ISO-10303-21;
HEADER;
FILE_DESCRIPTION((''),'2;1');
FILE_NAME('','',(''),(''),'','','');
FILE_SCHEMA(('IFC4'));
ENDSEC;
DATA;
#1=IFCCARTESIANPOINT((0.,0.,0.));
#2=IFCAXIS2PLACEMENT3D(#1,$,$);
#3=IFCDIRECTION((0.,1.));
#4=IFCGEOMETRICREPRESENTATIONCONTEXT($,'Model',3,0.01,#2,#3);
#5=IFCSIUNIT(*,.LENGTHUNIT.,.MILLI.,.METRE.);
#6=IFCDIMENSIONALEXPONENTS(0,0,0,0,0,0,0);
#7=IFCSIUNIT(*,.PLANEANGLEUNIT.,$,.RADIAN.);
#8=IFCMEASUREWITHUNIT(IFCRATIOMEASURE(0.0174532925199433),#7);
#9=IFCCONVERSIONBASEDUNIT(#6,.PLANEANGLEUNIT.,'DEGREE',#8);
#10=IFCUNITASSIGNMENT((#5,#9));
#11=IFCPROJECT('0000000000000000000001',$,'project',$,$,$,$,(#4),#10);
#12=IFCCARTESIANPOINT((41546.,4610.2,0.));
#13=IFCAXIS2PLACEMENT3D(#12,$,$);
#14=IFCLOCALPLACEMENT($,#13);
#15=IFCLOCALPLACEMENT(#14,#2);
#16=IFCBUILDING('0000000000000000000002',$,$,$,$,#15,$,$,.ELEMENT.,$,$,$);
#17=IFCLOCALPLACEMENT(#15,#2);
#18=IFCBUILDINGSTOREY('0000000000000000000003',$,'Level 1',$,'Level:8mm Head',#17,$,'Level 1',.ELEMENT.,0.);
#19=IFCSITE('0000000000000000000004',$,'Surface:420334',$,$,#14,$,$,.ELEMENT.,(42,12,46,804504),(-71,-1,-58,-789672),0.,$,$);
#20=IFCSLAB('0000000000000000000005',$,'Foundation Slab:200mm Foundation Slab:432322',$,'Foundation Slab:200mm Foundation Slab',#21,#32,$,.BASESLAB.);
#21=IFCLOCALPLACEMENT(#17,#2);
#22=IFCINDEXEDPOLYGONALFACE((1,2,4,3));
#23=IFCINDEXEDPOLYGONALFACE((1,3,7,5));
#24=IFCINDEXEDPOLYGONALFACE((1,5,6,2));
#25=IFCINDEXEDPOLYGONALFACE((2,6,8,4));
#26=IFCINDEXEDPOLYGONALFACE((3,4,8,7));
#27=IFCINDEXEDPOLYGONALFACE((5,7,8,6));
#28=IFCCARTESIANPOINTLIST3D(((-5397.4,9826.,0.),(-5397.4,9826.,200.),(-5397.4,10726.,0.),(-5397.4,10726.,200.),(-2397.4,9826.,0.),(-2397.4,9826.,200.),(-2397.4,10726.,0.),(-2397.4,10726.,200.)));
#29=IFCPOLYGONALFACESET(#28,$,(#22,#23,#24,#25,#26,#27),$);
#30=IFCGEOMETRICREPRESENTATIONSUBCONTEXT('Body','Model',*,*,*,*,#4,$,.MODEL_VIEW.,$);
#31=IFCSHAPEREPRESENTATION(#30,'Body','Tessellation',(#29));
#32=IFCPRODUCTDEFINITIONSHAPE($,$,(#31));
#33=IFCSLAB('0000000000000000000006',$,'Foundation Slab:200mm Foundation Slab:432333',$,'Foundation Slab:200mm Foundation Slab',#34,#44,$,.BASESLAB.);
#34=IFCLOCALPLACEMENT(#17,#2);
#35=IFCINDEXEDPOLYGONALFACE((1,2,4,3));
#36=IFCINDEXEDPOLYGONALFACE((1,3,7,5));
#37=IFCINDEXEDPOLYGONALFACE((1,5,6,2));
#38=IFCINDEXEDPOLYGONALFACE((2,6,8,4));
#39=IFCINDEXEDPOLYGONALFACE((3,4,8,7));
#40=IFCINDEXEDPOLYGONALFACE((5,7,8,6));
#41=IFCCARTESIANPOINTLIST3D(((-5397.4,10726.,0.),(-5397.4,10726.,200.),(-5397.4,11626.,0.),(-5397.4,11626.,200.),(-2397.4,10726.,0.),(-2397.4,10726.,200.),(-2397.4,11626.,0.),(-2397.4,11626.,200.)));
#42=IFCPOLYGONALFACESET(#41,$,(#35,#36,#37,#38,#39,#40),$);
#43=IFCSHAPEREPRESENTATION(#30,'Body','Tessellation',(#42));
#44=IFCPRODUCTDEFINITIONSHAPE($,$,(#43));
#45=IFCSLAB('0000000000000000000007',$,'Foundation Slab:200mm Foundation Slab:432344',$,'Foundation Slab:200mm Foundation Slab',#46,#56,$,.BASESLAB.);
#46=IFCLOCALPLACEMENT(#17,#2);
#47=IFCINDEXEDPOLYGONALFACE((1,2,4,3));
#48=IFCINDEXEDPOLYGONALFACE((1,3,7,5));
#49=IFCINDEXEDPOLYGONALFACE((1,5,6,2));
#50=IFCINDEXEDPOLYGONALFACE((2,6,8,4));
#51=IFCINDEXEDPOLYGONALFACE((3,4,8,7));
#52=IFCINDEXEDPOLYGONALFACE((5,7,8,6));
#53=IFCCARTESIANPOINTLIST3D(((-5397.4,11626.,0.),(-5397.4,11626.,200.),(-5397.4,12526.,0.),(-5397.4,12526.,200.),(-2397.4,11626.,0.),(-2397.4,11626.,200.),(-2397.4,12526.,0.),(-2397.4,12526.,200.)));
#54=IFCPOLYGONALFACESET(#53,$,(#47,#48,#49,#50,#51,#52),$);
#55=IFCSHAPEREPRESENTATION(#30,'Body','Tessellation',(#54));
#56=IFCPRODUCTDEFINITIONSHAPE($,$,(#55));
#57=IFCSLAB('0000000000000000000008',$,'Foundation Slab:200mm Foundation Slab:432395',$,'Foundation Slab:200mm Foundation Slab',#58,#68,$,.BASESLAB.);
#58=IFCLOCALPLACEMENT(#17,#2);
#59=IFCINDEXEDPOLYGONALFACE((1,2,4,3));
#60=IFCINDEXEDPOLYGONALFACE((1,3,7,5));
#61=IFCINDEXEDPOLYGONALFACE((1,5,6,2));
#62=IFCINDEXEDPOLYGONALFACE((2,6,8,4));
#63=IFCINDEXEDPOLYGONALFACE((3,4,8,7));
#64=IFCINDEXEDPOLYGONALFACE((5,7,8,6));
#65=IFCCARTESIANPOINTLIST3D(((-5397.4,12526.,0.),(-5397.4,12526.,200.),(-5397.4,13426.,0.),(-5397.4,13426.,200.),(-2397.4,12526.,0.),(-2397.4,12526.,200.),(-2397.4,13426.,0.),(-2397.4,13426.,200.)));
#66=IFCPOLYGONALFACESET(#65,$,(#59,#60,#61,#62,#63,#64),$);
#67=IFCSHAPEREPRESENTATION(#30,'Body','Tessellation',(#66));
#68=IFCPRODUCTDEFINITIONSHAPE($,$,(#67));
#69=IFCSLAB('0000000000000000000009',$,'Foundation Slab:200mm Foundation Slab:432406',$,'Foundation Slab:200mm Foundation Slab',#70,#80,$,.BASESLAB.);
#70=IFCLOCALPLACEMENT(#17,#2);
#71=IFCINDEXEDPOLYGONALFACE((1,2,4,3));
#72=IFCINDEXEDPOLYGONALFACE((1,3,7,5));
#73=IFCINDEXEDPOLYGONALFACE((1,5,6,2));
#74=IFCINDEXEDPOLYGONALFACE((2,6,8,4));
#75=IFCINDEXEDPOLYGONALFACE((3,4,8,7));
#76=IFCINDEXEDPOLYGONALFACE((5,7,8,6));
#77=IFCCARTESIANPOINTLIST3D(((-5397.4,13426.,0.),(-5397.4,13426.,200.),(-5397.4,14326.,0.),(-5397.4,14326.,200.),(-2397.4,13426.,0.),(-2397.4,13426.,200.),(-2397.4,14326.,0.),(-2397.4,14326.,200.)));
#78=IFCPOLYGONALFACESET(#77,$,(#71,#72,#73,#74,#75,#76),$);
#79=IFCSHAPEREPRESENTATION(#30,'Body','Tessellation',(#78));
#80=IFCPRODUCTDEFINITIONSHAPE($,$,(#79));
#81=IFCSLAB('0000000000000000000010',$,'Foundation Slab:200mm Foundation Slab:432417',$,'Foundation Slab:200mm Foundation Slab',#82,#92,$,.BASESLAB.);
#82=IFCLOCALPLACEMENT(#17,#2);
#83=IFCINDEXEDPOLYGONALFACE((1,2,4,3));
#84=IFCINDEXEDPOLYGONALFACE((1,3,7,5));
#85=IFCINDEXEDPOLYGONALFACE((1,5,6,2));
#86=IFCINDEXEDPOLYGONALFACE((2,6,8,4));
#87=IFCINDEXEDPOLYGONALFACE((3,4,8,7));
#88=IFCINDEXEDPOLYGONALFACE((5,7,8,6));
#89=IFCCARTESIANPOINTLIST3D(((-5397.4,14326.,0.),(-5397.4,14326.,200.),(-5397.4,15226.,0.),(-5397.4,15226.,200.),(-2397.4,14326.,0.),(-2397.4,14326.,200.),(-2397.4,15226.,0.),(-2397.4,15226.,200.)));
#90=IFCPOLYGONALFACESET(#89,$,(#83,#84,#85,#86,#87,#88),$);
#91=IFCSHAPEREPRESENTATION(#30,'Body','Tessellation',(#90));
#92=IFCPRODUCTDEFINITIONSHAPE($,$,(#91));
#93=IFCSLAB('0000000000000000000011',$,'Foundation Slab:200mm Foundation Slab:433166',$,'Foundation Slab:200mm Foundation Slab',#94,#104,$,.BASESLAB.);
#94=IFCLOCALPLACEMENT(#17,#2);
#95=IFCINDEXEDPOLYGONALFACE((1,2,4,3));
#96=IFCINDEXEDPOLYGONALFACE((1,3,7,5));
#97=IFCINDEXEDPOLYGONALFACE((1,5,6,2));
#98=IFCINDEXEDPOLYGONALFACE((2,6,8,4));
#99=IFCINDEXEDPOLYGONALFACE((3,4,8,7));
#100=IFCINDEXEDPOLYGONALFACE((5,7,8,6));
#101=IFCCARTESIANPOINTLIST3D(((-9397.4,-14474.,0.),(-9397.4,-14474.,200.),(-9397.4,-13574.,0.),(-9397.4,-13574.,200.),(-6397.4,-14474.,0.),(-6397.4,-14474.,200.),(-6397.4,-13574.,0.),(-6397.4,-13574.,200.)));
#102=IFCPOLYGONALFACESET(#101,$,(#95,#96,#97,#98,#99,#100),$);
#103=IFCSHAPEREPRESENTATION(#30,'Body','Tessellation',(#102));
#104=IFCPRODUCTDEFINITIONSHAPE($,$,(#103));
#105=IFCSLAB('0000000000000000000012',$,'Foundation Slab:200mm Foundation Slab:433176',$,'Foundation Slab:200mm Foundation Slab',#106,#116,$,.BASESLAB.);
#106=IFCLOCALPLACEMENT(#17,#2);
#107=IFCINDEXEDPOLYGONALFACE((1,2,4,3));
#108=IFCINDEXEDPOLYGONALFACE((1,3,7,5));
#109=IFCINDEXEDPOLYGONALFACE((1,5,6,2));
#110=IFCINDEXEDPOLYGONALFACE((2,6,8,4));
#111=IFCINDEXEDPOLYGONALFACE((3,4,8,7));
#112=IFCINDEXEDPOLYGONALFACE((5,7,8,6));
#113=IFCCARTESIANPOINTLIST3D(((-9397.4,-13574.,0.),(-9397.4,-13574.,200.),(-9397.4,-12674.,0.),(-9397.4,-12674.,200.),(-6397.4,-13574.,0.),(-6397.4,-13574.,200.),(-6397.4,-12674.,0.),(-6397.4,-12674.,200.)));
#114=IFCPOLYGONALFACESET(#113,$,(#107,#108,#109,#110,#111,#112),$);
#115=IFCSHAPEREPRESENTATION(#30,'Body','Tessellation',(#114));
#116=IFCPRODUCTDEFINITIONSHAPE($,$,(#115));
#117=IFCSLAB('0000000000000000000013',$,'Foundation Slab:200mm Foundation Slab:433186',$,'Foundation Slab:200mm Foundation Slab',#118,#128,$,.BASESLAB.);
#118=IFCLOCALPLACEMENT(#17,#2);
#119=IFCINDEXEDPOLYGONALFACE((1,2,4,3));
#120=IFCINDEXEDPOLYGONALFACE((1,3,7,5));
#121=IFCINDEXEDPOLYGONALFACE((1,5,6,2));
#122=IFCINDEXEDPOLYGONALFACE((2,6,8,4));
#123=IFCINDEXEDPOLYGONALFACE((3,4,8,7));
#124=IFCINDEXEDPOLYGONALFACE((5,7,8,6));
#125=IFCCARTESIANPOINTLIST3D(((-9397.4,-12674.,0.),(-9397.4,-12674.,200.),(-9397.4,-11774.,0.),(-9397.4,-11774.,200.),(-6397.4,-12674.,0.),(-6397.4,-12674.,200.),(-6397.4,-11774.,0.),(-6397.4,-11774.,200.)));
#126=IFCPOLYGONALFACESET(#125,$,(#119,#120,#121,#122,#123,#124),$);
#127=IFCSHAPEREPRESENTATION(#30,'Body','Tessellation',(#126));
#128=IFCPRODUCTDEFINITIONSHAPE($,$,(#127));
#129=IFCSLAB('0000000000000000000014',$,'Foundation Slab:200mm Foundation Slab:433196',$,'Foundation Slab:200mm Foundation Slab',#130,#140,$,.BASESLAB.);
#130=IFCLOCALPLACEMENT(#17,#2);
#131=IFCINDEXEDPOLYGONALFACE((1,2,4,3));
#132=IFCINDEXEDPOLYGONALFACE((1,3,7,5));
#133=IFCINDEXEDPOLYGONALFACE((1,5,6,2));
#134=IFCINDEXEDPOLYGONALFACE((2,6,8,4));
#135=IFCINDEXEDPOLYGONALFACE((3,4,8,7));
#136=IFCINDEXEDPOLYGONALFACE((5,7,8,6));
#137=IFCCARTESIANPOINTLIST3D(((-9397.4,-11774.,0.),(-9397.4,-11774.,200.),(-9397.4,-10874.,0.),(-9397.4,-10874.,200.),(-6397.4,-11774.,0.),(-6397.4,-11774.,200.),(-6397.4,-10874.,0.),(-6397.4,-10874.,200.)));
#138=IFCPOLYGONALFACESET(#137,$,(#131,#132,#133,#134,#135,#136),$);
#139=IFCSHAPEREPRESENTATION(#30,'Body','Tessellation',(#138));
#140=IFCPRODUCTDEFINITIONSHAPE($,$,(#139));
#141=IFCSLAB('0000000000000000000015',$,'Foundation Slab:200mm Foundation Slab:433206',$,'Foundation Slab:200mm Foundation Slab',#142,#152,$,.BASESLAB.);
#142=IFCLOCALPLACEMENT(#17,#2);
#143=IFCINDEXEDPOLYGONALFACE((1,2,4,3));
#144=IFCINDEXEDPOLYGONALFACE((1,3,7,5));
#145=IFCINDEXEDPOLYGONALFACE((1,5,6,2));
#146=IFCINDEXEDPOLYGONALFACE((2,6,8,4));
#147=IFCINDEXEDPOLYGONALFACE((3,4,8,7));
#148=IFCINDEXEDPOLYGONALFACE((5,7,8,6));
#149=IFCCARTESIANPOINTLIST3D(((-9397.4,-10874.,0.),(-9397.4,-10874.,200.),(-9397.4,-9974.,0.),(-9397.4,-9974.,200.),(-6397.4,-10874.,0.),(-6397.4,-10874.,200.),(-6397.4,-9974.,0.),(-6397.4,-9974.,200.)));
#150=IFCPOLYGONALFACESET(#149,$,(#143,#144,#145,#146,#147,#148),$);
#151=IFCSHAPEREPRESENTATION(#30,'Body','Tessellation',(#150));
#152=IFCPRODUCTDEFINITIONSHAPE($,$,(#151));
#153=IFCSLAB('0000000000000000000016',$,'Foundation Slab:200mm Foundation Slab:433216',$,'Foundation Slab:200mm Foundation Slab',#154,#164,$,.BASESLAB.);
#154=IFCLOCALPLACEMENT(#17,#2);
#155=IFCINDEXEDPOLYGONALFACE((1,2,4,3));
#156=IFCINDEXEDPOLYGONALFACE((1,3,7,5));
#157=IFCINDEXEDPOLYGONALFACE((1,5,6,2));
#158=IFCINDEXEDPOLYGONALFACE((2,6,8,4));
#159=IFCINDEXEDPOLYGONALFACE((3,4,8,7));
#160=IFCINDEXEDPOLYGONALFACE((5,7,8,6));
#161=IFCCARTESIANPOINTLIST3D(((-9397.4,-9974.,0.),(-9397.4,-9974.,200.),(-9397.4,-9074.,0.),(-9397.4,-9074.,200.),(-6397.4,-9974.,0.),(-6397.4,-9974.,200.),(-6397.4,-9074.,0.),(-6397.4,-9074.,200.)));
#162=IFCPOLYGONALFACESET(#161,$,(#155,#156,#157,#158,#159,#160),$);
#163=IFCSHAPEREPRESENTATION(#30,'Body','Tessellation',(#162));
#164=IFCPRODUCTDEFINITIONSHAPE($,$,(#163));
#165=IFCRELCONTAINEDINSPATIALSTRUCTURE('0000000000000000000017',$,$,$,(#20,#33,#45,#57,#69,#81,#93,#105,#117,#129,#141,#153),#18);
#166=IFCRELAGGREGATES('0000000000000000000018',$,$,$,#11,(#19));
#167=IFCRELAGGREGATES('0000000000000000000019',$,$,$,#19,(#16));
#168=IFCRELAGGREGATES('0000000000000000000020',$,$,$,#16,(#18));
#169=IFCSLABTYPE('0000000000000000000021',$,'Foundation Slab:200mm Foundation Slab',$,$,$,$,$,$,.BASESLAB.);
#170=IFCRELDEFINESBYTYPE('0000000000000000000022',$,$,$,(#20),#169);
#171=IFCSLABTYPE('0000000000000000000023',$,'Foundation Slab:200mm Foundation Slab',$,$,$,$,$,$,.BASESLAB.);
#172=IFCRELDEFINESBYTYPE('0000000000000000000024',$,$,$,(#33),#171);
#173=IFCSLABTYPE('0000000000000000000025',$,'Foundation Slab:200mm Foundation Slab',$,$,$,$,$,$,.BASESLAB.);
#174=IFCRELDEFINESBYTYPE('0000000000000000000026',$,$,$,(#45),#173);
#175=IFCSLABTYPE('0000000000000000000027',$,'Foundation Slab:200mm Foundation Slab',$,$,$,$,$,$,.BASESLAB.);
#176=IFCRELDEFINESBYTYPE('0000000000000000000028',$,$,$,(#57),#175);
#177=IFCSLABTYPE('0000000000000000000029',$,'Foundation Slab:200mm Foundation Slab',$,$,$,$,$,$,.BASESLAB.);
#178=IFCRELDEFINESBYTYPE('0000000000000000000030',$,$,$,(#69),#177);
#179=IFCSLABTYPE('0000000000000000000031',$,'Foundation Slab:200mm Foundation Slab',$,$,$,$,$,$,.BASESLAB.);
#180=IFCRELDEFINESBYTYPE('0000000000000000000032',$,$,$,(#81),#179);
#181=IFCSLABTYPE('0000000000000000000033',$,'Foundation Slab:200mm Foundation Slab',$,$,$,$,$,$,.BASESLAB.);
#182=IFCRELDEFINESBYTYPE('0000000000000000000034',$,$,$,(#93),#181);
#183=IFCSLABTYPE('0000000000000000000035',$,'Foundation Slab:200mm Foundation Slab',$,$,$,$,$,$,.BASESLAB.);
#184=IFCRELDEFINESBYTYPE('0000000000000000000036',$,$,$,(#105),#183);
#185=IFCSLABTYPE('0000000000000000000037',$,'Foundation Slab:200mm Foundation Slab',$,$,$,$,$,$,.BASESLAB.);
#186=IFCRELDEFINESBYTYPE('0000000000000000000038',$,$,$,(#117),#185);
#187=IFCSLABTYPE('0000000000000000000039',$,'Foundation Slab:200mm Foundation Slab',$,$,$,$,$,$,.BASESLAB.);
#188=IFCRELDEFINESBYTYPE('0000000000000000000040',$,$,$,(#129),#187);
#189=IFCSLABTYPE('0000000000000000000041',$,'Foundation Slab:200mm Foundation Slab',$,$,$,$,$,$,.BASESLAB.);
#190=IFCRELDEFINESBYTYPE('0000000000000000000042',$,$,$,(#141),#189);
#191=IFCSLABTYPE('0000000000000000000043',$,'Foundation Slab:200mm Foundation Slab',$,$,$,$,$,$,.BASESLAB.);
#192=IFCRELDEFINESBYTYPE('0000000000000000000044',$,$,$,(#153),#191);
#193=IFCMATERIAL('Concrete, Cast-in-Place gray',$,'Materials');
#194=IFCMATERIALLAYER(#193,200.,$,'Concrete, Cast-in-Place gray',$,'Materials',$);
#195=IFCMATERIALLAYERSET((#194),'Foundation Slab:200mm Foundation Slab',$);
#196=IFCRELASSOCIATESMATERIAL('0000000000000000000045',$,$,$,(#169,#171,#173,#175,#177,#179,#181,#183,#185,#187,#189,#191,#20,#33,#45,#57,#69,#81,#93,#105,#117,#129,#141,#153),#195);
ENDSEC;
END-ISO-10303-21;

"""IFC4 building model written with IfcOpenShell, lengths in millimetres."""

from ifc_helpers import new_model, entity, si_unit, converted_unit, direction, frame, frame_2d, origin, origin_2d_with_axis, place, context, subcontext, project, spatial, rectangle, extrude, material, layer, layer_set, layer_usage, type_object, element, save


model = new_model("IFC4")

# Units and contexts
model_context = context("Model", 3, precision=0.01, world=origin(), true_north=direction((0.0, 1.0)))
body_context = subcontext(model_context, "Body", "Model", "MODEL_VIEW")
ifc_project = project(units=[si_unit("LENGTHUNIT", "METRE", prefix="MILLI"), converted_unit("PLANEANGLEUNIT", "DEGREE", entity("IfcRatioMeasure", 0.0174532925199433), si_unit("PLANEANGLEUNIT", "RADIAN"), dimensions=[0, 0, 0, 0, 0, 0, 0])], contexts=[model_context])

# Site, building, storey
site_placement = place(None, frame((41546.0, 4610.2, 0.0)))
site = spatial("IfcSite", under=ifc_project, at=site_placement, Name="Surface:420334", CompositionType="ELEMENT", RefLatitude=(42, 12, 46, 804504), RefLongitude=(-71, -1, -58, -789672), RefElevation=0.0)
building_placement = place(site_placement, origin())
building = spatial("IfcBuilding", under=site, at=building_placement, CompositionType="ELEMENT")
storey_placement = place(building_placement, origin())
storey = spatial("IfcBuildingStorey", under=building, at=storey_placement, Name="Level 1", ObjectType="Level:8mm Head", LongName="Level 1", CompositionType="ELEMENT", Elevation=0.0)

# Slabs
ifc_material = material(Name="Concrete, Cast-in-Place gray", Category="Materials")
ifc_layer = layer(ifc_material, 200.0, Name="Concrete, Cast-in-Place gray", Category="Materials")
ifc_layer_set = layer_set([ifc_layer], Name="Foundation Slab:200mm Foundation Slab")
ifc_layer_usage_1 = layer_usage(ifc_layer_set, "AXIS3", "POSITIVE", 0.0)
slab_type_1 = type_object("IfcSlabType", Name="Foundation Slab:200mm Foundation Slab", PredefinedType="BASESLAB", material=ifc_layer_set)
slab_1_placement = place(storey_placement, origin())
element("IfcSlab", 1, at=slab_1_placement, inside=storey, type_object=slab_type_1, material=ifc_layer_usage_1, Name="Foundation Slab:200mm Foundation Slab:432322", ObjectType="Foundation Slab:200mm Foundation Slab", PredefinedType="BASESLAB", context=body_context, shape_type="SweptSolid", body=[
    extrude(rectangle(XDim=900.0, YDim=3000.0, at=origin_2d_with_axis()), frame((-3897.4, 10276.0, 200.0), z_axis=(0.0, 0.0, -1.0), x_axis=(0.0, 1.0, 0.0)), (0.0, 0.0, 1.0), 200.0),
])
ifc_layer_usage_2 = layer_usage(ifc_layer_set, "AXIS3", "POSITIVE", 0.0)
slab_type_2 = type_object("IfcSlabType", Name="Foundation Slab:200mm Foundation Slab", PredefinedType="BASESLAB", material=ifc_layer_set)
slab_2_placement = place(storey_placement, origin())
element("IfcSlab", 2, at=slab_2_placement, inside=storey, type_object=slab_type_2, material=ifc_layer_usage_2, Name="Foundation Slab:200mm Foundation Slab:432333", ObjectType="Foundation Slab:200mm Foundation Slab", PredefinedType="BASESLAB", context=body_context, shape_type="SweptSolid", body=[
    extrude(rectangle(XDim=900.0, YDim=3000.0, at=origin_2d_with_axis()), frame((-3897.4, 11176.0, 200.0), z_axis=(0.0, 0.0, -1.0), x_axis=(0.0, 1.0, 0.0)), (0.0, 0.0, 1.0), 200.0),
])
ifc_layer_usage_3 = layer_usage(ifc_layer_set, "AXIS3", "POSITIVE", 0.0)
slab_type_3 = type_object("IfcSlabType", Name="Foundation Slab:200mm Foundation Slab", PredefinedType="BASESLAB", material=ifc_layer_set)
slab_3_placement = place(storey_placement, origin())
element("IfcSlab", 3, at=slab_3_placement, inside=storey, type_object=slab_type_3, material=ifc_layer_usage_3, Name="Foundation Slab:200mm Foundation Slab:432344", ObjectType="Foundation Slab:200mm Foundation Slab", PredefinedType="BASESLAB", context=body_context, shape_type="SweptSolid", body=[
    extrude(rectangle(XDim=900.0, YDim=3000.0, at=origin_2d_with_axis()), frame((-3897.4, 12076.0, 200.0), z_axis=(0.0, 0.0, -1.0), x_axis=(0.0, 1.0, 0.0)), (0.0, 0.0, 1.0), 200.0),
])
ifc_layer_usage_4 = layer_usage(ifc_layer_set, "AXIS3", "POSITIVE", 0.0)
slab_type_4 = type_object("IfcSlabType", Name="Foundation Slab:200mm Foundation Slab", PredefinedType="BASESLAB", material=ifc_layer_set)
slab_4_placement = place(storey_placement, origin())
element("IfcSlab", 4, at=slab_4_placement, inside=storey, type_object=slab_type_4, material=ifc_layer_usage_4, Name="Foundation Slab:200mm Foundation Slab:432395", ObjectType="Foundation Slab:200mm Foundation Slab", PredefinedType="BASESLAB", context=body_context, shape_type="SweptSolid", body=[
    extrude(rectangle(XDim=900.0, YDim=3000.0, at=frame_2d((0.0, 0.0), x_axis=(1.0, 0.0))), frame((-3897.4, 12976.0, 200.0), z_axis=(0.0, 0.0, -1.0), x_axis=(0.0, 1.0, 0.0)), (0.0, 0.0, 1.0), 200.0),
])
ifc_layer_usage_5 = layer_usage(ifc_layer_set, "AXIS3", "POSITIVE", 0.0)
slab_type_5 = type_object("IfcSlabType", Name="Foundation Slab:200mm Foundation Slab", PredefinedType="BASESLAB", material=ifc_layer_set)
slab_5_placement = place(storey_placement, origin())
element("IfcSlab", 5, at=slab_5_placement, inside=storey, type_object=slab_type_5, material=ifc_layer_usage_5, Name="Foundation Slab:200mm Foundation Slab:432406", ObjectType="Foundation Slab:200mm Foundation Slab", PredefinedType="BASESLAB", context=body_context, shape_type="SweptSolid", body=[
    extrude(rectangle(XDim=900.0, YDim=3000.0, at=origin_2d_with_axis()), frame((-3897.4, 13876.0, 200.0), z_axis=(0.0, 0.0, -1.0), x_axis=(0.0, 1.0, 0.0)), (0.0, 0.0, 1.0), 200.0),
])
ifc_layer_usage_6 = layer_usage(ifc_layer_set, "AXIS3", "POSITIVE", 0.0)
slab_type_6 = type_object("IfcSlabType", Name="Foundation Slab:200mm Foundation Slab", PredefinedType="BASESLAB", material=ifc_layer_set)
slab_6_placement = place(storey_placement, origin())
element("IfcSlab", 6, at=slab_6_placement, inside=storey, type_object=slab_type_6, material=ifc_layer_usage_6, Name="Foundation Slab:200mm Foundation Slab:432417", ObjectType="Foundation Slab:200mm Foundation Slab", PredefinedType="BASESLAB", context=body_context, shape_type="SweptSolid", body=[
    extrude(rectangle(XDim=900.0, YDim=3000.0, at=frame_2d((0.0, 0.0), x_axis=(1.0, 0.0))), frame((-3897.4, 14776.0, 200.0), z_axis=(0.0, 0.0, -1.0), x_axis=(0.0, 1.0, 0.0)), (0.0, 0.0, 1.0), 200.0),
])
ifc_layer_usage_7 = layer_usage(ifc_layer_set, "AXIS3", "POSITIVE", 0.0)
slab_type_7 = type_object("IfcSlabType", Name="Foundation Slab:200mm Foundation Slab", PredefinedType="BASESLAB", material=ifc_layer_set)
slab_7_placement = place(storey_placement, origin())
element("IfcSlab", 7, at=slab_7_placement, inside=storey, type_object=slab_type_7, material=ifc_layer_usage_7, Name="Foundation Slab:200mm Foundation Slab:433166", ObjectType="Foundation Slab:200mm Foundation Slab", PredefinedType="BASESLAB", context=body_context, shape_type="SweptSolid", body=[
    extrude(rectangle(XDim=900.0, YDim=3000.0, at=frame_2d((0.0, 0.0), x_axis=(1.0, 0.0))), frame((-7897.4, -14024.0, 200.0), z_axis=(0.0, 0.0, -1.0), x_axis=(0.0, 1.0, 0.0)), (0.0, 0.0, 1.0), 200.0),
])
ifc_layer_usage_8 = layer_usage(ifc_layer_set, "AXIS3", "POSITIVE", 0.0)
slab_type_8 = type_object("IfcSlabType", Name="Foundation Slab:200mm Foundation Slab", PredefinedType="BASESLAB", material=ifc_layer_set)
slab_8_placement = place(storey_placement, origin())
element("IfcSlab", 8, at=slab_8_placement, inside=storey, type_object=slab_type_8, material=ifc_layer_usage_8, Name="Foundation Slab:200mm Foundation Slab:433176", ObjectType="Foundation Slab:200mm Foundation Slab", PredefinedType="BASESLAB", context=body_context, shape_type="SweptSolid", body=[
    extrude(rectangle(XDim=900.0, YDim=3000.0, at=frame_2d((0.0, 0.0), x_axis=(1.0, 0.0))), frame((-7897.4, -13124.0, 200.0), z_axis=(0.0, 0.0, -1.0), x_axis=(0.0, 1.0, 0.0)), (0.0, 0.0, 1.0), 200.0),
])
ifc_layer_usage_9 = layer_usage(ifc_layer_set, "AXIS3", "POSITIVE", 0.0)
slab_type_9 = type_object("IfcSlabType", Name="Foundation Slab:200mm Foundation Slab", PredefinedType="BASESLAB", material=ifc_layer_set)
slab_9_placement = place(storey_placement, origin())
element("IfcSlab", 9, at=slab_9_placement, inside=storey, type_object=slab_type_9, material=ifc_layer_usage_9, Name="Foundation Slab:200mm Foundation Slab:433186", ObjectType="Foundation Slab:200mm Foundation Slab", PredefinedType="BASESLAB", context=body_context, shape_type="SweptSolid", body=[
    extrude(rectangle(XDim=900.0, YDim=3000.0, at=frame_2d((0.0, 0.0), x_axis=(1.0, 0.0))), frame((-7897.4, -12224.0, 200.0), z_axis=(0.0, 0.0, -1.0), x_axis=(0.0, 1.0, 0.0)), (0.0, 0.0, 1.0), 200.0),
])
ifc_layer_usage_10 = layer_usage(ifc_layer_set, "AXIS3", "POSITIVE", 0.0)
slab_type_10 = type_object("IfcSlabType", Name="Foundation Slab:200mm Foundation Slab", PredefinedType="BASESLAB", material=ifc_layer_set)
slab_10_placement = place(storey_placement, origin())
element("IfcSlab", 10, at=slab_10_placement, inside=storey, type_object=slab_type_10, material=ifc_layer_usage_10, Name="Foundation Slab:200mm Foundation Slab:433196", ObjectType="Foundation Slab:200mm Foundation Slab", PredefinedType="BASESLAB", context=body_context, shape_type="SweptSolid", body=[
    extrude(rectangle(XDim=900.0, YDim=3000.0, at=frame_2d((0.0, 0.0), x_axis=(1.0, 0.0))), frame((-7897.4, -11324.0, 200.0), z_axis=(0.0, 0.0, -1.0), x_axis=(0.0, 1.0, 0.0)), (0.0, 0.0, 1.0), 200.0),
])
ifc_layer_usage_11 = layer_usage(ifc_layer_set, "AXIS3", "POSITIVE", 0.0)
slab_type_11 = type_object("IfcSlabType", Name="Foundation Slab:200mm Foundation Slab", PredefinedType="BASESLAB", material=ifc_layer_set)
slab_11_placement = place(storey_placement, origin())
element("IfcSlab", 11, at=slab_11_placement, inside=storey, type_object=slab_type_11, material=ifc_layer_usage_11, Name="Foundation Slab:200mm Foundation Slab:433206", ObjectType="Foundation Slab:200mm Foundation Slab", PredefinedType="BASESLAB", context=body_context, shape_type="SweptSolid", body=[
    extrude(rectangle(XDim=900.0, YDim=3000.0, at=frame_2d((0.0, 0.0), x_axis=(1.0, 0.0))), frame((-7897.4, -10424.0, 200.0), z_axis=(0.0, 0.0, -1.0), x_axis=(0.0, 1.0, 0.0)), (0.0, 0.0, 1.0), 200.0),
])
ifc_layer_usage_12 = layer_usage(ifc_layer_set, "AXIS3", "POSITIVE", 0.0)
slab_type_12 = type_object("IfcSlabType", Name="Foundation Slab:200mm Foundation Slab", PredefinedType="BASESLAB", material=ifc_layer_set)
slab_12_placement = place(storey_placement, origin())
element("IfcSlab", 12, at=slab_12_placement, inside=storey, type_object=slab_type_12, material=ifc_layer_usage_12, Name="Foundation Slab:200mm Foundation Slab:433216", ObjectType="Foundation Slab:200mm Foundation Slab", PredefinedType="BASESLAB", context=body_context, shape_type="SweptSolid", body=[
    extrude(rectangle(XDim=900.0, YDim=3000.0, at=frame_2d((0.0, 0.0), x_axis=(1.0, 0.0))), frame((-7897.4, -9524.0, 200.0), z_axis=(0.0, 0.0, -1.0), x_axis=(0.0, 1.0, 0.0)), (0.0, 0.0, 1.0), 200.0),
])

save(model, "model.ifc")
